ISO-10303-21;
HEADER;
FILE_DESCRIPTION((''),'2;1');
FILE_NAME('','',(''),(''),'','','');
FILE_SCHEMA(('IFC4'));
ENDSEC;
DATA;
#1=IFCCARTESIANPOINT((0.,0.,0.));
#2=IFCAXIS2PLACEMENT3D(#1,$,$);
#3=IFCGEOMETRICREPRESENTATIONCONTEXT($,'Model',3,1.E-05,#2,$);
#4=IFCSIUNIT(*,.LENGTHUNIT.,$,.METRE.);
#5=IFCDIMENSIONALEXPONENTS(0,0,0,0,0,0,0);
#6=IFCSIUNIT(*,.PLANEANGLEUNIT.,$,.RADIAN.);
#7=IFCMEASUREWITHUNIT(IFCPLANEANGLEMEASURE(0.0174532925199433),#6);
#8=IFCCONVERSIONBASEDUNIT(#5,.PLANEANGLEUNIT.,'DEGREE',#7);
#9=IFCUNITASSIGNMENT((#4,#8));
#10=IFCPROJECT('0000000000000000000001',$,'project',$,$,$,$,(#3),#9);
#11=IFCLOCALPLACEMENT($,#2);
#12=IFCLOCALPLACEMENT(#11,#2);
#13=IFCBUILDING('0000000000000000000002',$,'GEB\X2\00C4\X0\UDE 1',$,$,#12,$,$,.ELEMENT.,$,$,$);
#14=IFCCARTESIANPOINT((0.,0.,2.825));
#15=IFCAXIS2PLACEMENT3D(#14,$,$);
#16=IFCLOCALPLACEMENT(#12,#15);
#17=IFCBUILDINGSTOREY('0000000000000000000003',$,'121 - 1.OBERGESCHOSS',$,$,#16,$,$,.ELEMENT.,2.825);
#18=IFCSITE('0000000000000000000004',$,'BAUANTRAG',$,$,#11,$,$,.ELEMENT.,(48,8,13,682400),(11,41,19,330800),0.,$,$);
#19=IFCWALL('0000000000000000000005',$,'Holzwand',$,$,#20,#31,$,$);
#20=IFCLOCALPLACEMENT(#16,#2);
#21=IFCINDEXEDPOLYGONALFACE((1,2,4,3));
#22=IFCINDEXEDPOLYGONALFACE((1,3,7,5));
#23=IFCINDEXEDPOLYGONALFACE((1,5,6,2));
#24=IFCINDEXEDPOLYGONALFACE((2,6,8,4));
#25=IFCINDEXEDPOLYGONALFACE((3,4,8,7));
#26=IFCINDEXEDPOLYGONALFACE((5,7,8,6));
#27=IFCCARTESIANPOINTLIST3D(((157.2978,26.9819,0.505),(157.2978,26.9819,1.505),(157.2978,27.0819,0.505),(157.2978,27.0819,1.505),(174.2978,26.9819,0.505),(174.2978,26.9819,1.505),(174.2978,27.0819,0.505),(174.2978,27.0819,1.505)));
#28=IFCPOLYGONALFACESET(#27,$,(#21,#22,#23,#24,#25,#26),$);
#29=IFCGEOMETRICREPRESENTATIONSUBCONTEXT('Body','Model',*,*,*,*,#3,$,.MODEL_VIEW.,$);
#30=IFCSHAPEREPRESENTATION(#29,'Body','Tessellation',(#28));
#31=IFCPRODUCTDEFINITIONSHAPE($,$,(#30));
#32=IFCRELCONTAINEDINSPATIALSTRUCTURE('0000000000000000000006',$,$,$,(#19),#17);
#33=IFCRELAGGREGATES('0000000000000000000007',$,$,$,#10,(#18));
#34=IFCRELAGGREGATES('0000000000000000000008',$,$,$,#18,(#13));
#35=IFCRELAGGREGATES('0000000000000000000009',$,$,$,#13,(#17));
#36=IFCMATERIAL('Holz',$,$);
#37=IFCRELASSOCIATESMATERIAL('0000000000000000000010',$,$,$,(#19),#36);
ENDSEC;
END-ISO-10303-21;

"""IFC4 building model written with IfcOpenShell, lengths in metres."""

from ifc_helpers import new_model, entity, si_unit, converted_unit, frame, origin, origin_with_axes, place, context, subcontext, project, spatial, indexed_curve, outline, extrude, material, element, save


model = new_model("IFC4")

# Units and contexts
model_context = context("Model", 3, precision=1e-05, world=origin())
body_context = subcontext(model_context, "Body", "Model", "MODEL_VIEW")
ifc_project = project(units=[si_unit("LENGTHUNIT", "METRE"), converted_unit("PLANEANGLEUNIT", "DEGREE", entity("IfcPlaneAngleMeasure", 0.0174532925199433), si_unit("PLANEANGLEUNIT", "RADIAN"), dimensions=[0, 0, 0, 0, 0, 0, 0])], contexts=[model_context])

# Site, building, storey
site_placement = place(None, origin())
site = spatial("IfcSite", under=ifc_project, at=site_placement, Name="BAUANTRAG", CompositionType="ELEMENT", RefLatitude=(48, 8, 13, 682400), RefLongitude=(11, 41, 19, 330800), RefElevation=0.0)
building_placement = place(site_placement, origin())
building = spatial("IfcBuilding", under=site, at=building_placement, Name="GEBÄUDE 1", CompositionType="ELEMENT")
storey_placement = place(building_placement, frame((0.0, 0.0, 2.825)))
storey = spatial("IfcBuildingStorey", under=building, at=storey_placement, Name="121 - 1.OBERGESCHOSS", CompositionType="ELEMENT", Elevation=2.825)

# Wall
ifc_material_1 = material(Name="Holz")
wall_1_placement = place(storey_placement, frame((157.2978, 26.9819, 0.505)))
element("IfcWall", 1, at=wall_1_placement, inside=storey, material=ifc_material_1, Name="Holzwand", context=body_context, shape_type="SweptSolid", body=[
    extrude(outline(indexed_curve([(0.0, 0.0), (17.0, 0.0), (17.0, 0.1), (0.0, 0.1), (0.0, 0.0)], self_intersect=False)), origin_with_axes(), (0.0, 0.0, 1.0), 1.0),
])

save(model, "model.ifc")
